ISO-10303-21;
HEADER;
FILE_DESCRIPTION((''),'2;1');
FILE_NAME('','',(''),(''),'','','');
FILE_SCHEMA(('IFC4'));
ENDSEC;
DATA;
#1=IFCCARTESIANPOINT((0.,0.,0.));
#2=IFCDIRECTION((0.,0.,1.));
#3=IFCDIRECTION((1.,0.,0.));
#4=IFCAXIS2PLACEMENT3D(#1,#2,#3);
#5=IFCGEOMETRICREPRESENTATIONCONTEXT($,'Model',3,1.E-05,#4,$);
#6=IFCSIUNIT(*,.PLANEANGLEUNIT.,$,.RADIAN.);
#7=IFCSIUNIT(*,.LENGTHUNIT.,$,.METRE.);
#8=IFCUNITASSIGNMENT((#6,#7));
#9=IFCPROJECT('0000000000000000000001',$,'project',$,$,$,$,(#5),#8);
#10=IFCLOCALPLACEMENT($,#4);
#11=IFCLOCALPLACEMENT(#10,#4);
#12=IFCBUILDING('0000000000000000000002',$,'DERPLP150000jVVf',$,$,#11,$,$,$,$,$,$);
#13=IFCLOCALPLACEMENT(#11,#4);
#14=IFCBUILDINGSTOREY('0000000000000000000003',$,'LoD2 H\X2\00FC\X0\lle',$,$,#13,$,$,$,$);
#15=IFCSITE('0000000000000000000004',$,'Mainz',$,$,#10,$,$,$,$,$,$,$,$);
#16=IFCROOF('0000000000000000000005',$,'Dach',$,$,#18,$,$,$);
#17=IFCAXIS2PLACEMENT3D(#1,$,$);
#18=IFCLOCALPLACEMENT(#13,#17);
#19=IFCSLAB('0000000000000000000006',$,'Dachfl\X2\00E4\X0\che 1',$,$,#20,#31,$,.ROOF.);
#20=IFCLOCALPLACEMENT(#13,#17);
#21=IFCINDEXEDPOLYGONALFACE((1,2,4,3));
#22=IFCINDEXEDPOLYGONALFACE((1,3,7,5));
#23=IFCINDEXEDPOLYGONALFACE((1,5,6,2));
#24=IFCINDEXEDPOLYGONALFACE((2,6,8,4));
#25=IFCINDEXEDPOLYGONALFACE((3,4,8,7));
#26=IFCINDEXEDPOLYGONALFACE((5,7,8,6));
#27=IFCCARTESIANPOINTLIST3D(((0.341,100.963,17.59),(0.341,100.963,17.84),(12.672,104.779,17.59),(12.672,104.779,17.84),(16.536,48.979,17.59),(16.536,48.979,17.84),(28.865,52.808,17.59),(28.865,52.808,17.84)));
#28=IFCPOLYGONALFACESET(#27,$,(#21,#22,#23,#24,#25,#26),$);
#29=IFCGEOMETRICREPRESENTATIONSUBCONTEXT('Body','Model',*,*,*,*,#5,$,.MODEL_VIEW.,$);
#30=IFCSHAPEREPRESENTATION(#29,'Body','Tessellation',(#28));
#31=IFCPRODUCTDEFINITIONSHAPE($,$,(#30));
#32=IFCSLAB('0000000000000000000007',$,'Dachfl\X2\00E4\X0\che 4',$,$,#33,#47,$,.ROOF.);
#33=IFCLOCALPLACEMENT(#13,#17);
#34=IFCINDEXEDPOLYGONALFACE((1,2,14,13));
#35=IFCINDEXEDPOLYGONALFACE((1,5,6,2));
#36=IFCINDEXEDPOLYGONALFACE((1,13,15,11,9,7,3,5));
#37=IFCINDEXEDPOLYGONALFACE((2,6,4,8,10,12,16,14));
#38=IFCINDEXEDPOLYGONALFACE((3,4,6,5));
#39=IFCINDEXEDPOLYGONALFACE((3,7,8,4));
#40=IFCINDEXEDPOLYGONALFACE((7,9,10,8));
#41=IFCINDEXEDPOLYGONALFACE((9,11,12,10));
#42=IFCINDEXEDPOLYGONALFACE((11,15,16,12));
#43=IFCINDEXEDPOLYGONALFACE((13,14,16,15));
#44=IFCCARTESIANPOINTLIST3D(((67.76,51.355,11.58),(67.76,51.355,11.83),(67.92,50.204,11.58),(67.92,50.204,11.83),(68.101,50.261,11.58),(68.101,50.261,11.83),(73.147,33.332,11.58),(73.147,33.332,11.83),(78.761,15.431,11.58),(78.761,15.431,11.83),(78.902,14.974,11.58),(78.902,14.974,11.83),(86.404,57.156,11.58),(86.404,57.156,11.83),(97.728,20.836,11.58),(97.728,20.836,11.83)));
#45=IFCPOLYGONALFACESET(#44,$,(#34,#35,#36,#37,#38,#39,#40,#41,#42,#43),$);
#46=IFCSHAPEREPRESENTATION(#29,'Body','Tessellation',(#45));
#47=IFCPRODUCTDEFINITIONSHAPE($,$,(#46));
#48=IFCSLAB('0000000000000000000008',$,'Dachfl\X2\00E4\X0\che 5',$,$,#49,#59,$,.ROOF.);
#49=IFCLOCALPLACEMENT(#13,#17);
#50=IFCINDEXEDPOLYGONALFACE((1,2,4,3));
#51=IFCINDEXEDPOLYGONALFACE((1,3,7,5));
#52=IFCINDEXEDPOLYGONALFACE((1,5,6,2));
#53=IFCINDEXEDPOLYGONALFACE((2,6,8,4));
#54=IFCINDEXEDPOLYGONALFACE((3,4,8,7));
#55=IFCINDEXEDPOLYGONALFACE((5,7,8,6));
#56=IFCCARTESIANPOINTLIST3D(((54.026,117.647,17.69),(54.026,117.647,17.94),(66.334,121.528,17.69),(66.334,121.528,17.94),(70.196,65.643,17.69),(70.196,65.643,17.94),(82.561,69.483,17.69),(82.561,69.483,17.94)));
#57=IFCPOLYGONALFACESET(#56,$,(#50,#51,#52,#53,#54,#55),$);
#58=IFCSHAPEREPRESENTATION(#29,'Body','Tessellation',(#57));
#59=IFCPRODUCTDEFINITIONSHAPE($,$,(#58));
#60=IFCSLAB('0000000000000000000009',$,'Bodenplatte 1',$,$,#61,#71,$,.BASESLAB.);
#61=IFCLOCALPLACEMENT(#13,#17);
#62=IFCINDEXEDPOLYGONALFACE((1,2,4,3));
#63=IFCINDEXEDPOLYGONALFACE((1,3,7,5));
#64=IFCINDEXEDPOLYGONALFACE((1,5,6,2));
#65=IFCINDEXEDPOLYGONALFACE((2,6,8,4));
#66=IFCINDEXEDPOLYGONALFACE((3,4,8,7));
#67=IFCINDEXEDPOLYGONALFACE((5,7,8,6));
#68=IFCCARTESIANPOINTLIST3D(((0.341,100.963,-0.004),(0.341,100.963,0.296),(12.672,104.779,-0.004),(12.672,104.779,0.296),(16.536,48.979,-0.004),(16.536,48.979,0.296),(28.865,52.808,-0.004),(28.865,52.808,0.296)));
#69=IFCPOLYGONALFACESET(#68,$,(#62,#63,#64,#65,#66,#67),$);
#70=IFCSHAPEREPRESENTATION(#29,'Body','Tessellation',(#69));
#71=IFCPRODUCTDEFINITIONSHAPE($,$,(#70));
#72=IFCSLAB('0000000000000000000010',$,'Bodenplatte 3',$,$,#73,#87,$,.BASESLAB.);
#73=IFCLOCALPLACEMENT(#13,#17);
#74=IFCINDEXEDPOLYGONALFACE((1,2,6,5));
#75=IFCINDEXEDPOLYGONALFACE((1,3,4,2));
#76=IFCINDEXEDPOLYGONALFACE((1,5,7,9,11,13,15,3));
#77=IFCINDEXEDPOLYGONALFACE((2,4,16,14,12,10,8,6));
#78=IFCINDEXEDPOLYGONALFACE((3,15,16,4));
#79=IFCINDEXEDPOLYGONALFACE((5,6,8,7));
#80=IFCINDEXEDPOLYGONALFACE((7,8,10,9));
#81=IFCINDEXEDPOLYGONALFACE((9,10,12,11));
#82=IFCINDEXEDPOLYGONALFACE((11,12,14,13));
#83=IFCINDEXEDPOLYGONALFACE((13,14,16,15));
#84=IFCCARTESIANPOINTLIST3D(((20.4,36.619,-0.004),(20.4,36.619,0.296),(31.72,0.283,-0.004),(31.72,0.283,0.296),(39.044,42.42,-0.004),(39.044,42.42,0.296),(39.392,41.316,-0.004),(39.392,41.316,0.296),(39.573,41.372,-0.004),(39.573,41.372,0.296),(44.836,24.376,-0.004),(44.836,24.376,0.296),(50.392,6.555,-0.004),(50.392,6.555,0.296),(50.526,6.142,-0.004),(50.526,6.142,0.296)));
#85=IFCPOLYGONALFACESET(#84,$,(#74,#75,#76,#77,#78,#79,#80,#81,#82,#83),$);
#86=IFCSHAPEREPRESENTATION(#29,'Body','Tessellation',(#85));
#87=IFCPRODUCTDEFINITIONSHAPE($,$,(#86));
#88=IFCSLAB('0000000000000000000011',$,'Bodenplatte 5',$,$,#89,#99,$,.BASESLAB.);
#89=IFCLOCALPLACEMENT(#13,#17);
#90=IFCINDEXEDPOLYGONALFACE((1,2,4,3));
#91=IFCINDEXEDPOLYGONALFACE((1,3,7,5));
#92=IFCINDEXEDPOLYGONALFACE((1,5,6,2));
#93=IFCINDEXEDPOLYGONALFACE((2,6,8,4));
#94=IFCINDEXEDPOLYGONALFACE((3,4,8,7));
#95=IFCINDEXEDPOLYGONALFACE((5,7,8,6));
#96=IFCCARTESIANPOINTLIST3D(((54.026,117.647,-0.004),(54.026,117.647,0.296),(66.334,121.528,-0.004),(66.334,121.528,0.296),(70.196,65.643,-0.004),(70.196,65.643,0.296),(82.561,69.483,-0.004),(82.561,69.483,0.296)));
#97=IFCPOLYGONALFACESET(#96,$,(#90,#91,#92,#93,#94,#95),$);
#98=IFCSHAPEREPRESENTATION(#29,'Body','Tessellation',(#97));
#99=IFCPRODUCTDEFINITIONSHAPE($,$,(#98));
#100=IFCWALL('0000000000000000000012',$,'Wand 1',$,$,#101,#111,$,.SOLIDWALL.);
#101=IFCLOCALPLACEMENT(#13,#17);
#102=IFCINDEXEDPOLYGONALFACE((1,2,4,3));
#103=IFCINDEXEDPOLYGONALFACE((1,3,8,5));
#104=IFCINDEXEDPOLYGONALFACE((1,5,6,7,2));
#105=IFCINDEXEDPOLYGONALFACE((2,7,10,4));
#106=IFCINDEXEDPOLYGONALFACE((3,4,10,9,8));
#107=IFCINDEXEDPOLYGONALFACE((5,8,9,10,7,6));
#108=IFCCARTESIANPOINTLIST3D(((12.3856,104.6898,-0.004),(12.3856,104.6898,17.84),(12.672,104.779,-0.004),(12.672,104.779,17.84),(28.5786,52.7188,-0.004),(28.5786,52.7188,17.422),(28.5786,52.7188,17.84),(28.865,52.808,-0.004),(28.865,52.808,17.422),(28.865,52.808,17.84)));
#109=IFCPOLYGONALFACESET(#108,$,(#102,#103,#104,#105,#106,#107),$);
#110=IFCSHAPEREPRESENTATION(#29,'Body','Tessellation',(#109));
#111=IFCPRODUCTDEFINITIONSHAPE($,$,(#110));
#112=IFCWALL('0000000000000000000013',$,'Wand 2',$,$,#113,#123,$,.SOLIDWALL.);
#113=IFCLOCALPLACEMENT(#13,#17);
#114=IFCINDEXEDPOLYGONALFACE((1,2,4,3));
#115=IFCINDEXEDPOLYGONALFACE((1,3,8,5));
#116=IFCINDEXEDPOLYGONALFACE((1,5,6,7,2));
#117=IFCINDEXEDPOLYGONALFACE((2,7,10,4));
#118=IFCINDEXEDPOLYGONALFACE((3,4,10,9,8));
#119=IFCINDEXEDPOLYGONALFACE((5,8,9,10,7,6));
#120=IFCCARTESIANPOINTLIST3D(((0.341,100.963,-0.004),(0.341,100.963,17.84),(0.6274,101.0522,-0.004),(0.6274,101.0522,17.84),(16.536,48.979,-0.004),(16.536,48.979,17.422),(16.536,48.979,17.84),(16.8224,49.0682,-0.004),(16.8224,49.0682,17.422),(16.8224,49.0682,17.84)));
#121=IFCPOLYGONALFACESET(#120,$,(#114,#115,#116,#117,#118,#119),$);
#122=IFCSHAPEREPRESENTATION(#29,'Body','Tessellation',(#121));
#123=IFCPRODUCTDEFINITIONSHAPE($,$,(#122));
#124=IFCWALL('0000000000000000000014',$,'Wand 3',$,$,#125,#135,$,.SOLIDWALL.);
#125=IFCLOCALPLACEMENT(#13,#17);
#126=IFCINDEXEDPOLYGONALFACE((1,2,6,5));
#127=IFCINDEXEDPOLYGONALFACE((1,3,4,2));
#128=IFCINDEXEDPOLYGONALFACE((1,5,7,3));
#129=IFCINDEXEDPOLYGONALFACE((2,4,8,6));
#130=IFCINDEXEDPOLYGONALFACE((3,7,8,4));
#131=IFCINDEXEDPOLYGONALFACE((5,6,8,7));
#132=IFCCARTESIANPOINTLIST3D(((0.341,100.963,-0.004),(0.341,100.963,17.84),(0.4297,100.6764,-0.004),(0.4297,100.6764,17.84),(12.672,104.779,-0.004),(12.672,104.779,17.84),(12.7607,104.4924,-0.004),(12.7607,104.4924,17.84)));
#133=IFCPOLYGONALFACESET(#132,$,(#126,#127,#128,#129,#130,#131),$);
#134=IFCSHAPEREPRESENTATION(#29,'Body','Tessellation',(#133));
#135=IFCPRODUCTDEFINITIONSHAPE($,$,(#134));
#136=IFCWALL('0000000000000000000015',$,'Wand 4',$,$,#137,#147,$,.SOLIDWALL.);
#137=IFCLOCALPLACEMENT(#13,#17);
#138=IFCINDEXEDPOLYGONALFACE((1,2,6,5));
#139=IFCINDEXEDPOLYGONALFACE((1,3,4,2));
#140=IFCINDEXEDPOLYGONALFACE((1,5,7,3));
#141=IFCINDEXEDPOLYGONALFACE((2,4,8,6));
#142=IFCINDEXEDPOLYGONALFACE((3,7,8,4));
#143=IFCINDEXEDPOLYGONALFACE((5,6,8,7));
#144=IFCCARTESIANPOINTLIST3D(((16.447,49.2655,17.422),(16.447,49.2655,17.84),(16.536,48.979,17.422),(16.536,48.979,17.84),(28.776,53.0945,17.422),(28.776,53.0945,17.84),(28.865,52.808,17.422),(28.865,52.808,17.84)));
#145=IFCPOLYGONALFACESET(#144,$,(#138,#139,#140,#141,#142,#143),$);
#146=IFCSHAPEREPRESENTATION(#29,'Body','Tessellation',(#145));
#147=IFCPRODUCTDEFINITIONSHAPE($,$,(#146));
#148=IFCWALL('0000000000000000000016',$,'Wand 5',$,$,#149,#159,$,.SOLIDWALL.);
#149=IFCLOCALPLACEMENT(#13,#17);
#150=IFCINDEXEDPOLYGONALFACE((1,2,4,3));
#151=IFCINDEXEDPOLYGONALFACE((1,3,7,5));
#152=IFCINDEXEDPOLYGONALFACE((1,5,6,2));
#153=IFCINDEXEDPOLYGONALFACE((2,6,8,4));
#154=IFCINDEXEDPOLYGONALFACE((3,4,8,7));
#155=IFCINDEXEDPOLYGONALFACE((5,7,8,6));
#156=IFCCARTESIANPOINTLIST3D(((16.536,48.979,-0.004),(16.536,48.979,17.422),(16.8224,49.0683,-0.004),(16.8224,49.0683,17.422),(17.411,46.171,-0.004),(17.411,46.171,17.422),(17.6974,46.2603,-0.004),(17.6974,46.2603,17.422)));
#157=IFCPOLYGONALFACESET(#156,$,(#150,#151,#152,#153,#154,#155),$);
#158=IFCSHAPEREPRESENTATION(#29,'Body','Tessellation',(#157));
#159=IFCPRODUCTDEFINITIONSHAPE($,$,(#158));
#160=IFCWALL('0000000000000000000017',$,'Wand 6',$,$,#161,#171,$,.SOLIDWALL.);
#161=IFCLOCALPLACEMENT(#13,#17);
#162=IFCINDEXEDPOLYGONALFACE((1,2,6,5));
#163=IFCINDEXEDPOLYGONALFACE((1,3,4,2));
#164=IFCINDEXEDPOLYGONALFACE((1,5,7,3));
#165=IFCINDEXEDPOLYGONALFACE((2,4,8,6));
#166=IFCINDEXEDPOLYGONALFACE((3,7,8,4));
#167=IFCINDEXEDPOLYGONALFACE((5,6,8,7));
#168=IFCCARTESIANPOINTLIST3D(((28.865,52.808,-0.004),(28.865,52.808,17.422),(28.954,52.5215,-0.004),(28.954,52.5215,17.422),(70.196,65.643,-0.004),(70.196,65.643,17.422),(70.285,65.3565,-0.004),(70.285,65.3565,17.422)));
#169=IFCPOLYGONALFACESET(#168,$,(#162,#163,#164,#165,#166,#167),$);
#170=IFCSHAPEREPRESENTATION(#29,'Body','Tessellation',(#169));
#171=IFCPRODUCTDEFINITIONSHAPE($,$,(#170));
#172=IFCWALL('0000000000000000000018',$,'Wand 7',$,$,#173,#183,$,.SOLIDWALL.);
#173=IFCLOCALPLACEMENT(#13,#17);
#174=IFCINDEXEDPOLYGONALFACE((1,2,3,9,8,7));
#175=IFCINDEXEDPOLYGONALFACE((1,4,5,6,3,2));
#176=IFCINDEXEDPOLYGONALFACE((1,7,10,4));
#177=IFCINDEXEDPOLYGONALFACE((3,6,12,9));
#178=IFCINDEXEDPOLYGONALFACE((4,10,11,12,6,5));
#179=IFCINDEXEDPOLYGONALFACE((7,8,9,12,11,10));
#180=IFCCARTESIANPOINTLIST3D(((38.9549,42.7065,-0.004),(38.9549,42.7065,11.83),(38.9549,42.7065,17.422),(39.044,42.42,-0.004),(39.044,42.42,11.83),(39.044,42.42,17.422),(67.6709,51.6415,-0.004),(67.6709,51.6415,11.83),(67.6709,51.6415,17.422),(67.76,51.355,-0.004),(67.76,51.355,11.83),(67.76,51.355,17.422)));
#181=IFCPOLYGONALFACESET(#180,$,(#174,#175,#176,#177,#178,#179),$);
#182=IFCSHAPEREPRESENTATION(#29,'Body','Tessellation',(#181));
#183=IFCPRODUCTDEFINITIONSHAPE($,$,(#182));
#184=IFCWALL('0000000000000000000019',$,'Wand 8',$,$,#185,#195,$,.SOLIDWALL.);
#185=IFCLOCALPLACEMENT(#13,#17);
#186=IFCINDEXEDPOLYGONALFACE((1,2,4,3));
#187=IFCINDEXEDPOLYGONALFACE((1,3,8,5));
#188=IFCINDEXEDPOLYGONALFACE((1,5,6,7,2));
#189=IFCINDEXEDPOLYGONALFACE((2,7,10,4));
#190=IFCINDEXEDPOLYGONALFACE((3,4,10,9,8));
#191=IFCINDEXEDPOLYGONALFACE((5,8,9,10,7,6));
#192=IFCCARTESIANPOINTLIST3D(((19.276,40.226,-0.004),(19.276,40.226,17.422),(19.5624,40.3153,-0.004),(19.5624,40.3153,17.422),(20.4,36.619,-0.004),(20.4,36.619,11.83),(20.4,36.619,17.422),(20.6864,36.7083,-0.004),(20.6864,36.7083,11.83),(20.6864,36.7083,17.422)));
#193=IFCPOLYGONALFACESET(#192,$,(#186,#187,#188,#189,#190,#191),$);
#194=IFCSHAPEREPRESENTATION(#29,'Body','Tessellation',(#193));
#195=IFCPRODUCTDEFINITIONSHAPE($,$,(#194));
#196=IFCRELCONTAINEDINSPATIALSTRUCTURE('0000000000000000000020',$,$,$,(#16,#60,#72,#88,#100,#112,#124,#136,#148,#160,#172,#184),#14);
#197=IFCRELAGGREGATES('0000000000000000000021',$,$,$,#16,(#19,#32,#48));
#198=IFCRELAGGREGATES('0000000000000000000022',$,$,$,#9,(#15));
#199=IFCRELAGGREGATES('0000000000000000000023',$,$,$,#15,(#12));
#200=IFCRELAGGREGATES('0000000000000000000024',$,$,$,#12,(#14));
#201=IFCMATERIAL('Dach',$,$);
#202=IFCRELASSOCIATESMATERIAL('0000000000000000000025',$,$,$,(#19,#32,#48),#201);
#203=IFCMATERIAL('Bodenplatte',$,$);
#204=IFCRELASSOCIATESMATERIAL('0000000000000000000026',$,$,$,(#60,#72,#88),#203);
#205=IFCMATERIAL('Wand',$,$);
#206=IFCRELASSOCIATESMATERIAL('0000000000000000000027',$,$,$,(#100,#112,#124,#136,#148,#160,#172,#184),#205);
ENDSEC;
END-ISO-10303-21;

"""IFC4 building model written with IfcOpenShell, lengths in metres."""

from ifc_helpers import new_model, si_unit, frame, origin_with_axes, place, context, subcontext, project, spatial, polyline, outline, extrude, material, element, aggregate, save


model = new_model("IFC4")

# Units and contexts
model_context = context("Model", 3, precision=1e-05, world=origin_with_axes())
body_context = subcontext(model_context, "Body", "Model", "MODEL_VIEW")
ifc_project = project(units=[si_unit("PLANEANGLEUNIT", "RADIAN"), si_unit("LENGTHUNIT", "METRE")], contexts=[model_context])

# Site, building, storey
site_placement = place(None, origin_with_axes())
site = spatial("IfcSite", under=ifc_project, at=site_placement, Name="Mainz")
building_placement = place(site_placement, origin_with_axes())
building = spatial("IfcBuilding", under=site, at=building_placement, Name="DERPLP150000jVVf")
storey_placement = place(building_placement, origin_with_axes())
storey = spatial("IfcBuildingStorey", under=building, at=storey_placement, Name="LoD2 Hülle")

# Roof, slabs
roof_placement = place(storey_placement, origin_with_axes())
roof = element("IfcRoof", 1, at=roof_placement, inside=storey, Name="Dach")
ifc_material_1 = material(Name="Dach")
slab_1_placement = place(roof_placement, origin_with_axes())
slab_1 = element("IfcSlab", 2, at=slab_1_placement, material=ifc_material_1, Name="Dachfläche 1", PredefinedType="ROOF", context=body_context, shape_type="SweptSolid", body=[
    extrude(outline(polyline([(0.0, 0.0), (54.4483, 0.0), (54.4597, 12.9099), (0.0244, 12.9079), (0.0, 0.0)])), frame((0.341, 100.963, 17.84), z_axis=(0.0, 0.0, 1.0), x_axis=(0.297438, -0.954741, 0.0)), (0.0, 0.0, -1.0), 0.25),
])
slab_2_placement = place(roof_placement, origin_with_axes())
slab_2 = element("IfcSlab", 3, at=slab_2_placement, material=ifc_material_1, Name="Dachfläche 4", PredefinedType="ROOF", context=body_context, shape_type="SweptSolid", body=[
    extrude(outline(polyline([(0.0, 0.0), (38.0444, 0.0), (38.0558, 19.5256), (36.9098, 19.5257), (36.9093, 19.7155), (19.2462, 19.7474), (0.4856, 19.7161), (0.0073, 19.7175), (0.0, 0.0)])), frame((97.728, 20.836, 11.83), z_axis=(0.0, 0.0, 1.0), x_axis=(-0.297652, 0.954674, 0.0)), (0.0, 0.0, -1.0), 0.25),
])
slab_3_placement = place(roof_placement, origin_with_axes())
slab_3 = element("IfcSlab", 4, at=slab_3_placement, material=ifc_material_1, Name="Dachfläche 5", PredefinedType="ROOF", context=body_context, shape_type="SweptSolid", body=[
    extrude(outline(polyline([(0.0, 0.0), (54.516, 0.0), (54.4745, 12.9053), (0.0146, 12.9475), (0.0, 0.0)])), frame((82.561, 69.483, 17.94), z_axis=(0.0, 0.0, 1.0), x_axis=(-0.297656, 0.954673, 0.0)), (0.0, 0.0, -1.0), 0.25),
])
aggregate(roof, [slab_1, slab_2, slab_3])

# Slabs
ifc_material_2 = material(Name="Bodenplatte")
slab_4_placement = place(storey_placement, origin_with_axes())
element("IfcSlab", 5, at=slab_4_placement, inside=storey, material=ifc_material_2, Name="Bodenplatte 1", PredefinedType="BASESLAB", context=body_context, shape_type="SweptSolid", body=[
    extrude(outline(polyline([(0.0, 0.0), (54.4353, 0.0), (54.4234, 12.9099), (-0.0249, 12.9079), (0.0, 0.0)])), frame((12.672, 104.779, -0.004), z_axis=(0.0, 0.0, -1.0), x_axis=(0.297473, -0.95473, 0.0)), (0.0, 0.0, -1.0), 0.3),
])
slab_5_placement = place(storey_placement, origin_with_axes())
element("IfcSlab", 6, at=slab_5_placement, inside=storey, material=ifc_material_2, Name="Bodenplatte 3", PredefinedType="BASESLAB", context=body_context, shape_type="SweptSolid", body=[
    extrude(outline(polyline([(0.0, 0.0), (38.0585, 0.0), (38.0515, 19.5256), (36.894, 19.5295), (36.8936, 19.719), (19.1014, 19.6885), (0.4344, 19.6925), (0.0002, 19.6976), (0.0, 0.0)])), frame((31.72, 0.283, -0.004), z_axis=(0.0, 0.0, -1.0), x_axis=(-0.297437, 0.954741, 0.0)), (0.0, 0.0, -1.0), 0.3),
])
slab_6_placement = place(storey_placement, origin_with_axes())
element("IfcSlab", 7, at=slab_6_placement, inside=storey, material=ifc_material_2, Name="Bodenplatte 5", PredefinedType="BASESLAB", context=body_context, shape_type="SweptSolid", body=[
    extrude(outline(polyline([(0.0, 0.0), (54.4599, 0.0), (54.5115, 12.9053), (-0.0045, 12.9475), (0.0, 0.0)])), frame((70.196, 65.643, -0.004), z_axis=(0.0, 0.0, -1.0), x_axis=(-0.296916, 0.954904, 0.0)), (0.0, 0.0, -1.0), 0.3),
])

# Walls
ifc_material_3 = material(Name="Wand")
wall_1_placement = place(storey_placement, origin_with_axes())
element("IfcWall", 8, at=wall_1_placement, inside=storey, material=ifc_material_3, Name="Wand 1", PredefinedType="SOLIDWALL", context=body_context, shape_type="SweptSolid", body=[
    extrude(outline(polyline([(0.0, 0.0), (54.4353, 0.0), (54.4353, 0.418), (54.4353, 17.844), (0.0, 17.844), (0.0, 0.0)])), frame((12.672, 104.779, 17.84), z_axis=(0.95473, 0.297473, 0.0), x_axis=(0.297473, -0.95473, 0.0)), (0.0, 0.0, -1.0), 0.3),
])
wall_2_placement = place(storey_placement, origin_with_axes())
element("IfcWall", 9, at=wall_2_placement, inside=storey, material=ifc_material_3, Name="Wand 2", PredefinedType="SOLIDWALL", context=body_context, shape_type="SweptSolid", body=[
    extrude(outline(polyline([(0.0, 0.0), (54.4483, 0.0), (54.4483, 17.844), (0.0, 17.844), (0.0, 0.418), (0.0, 0.0)])), frame((16.536, 48.979, 17.84), z_axis=(-0.954741, -0.297438, 0.0), x_axis=(-0.297438, 0.954741, 0.0)), (0.0, 0.0, -1.0), 0.3),
])
wall_3_placement = place(storey_placement, origin_with_axes())
element("IfcWall", 10, at=wall_3_placement, inside=storey, material=ifc_material_3, Name="Wand 3", PredefinedType="SOLIDWALL", context=body_context, shape_type="SweptSolid", body=[
    extrude(outline(polyline([(0.0, 0.0), (12.908, 0.0), (12.908, 17.844), (0.0, 17.844), (0.0, 0.0)])), frame((0.341, 100.963, 17.84), z_axis=(-0.295632, 0.955302, 0.0), x_axis=(0.955302, 0.295632, 0.0)), (0.0, 0.0, -1.0), 0.3),
])
wall_4_placement = place(storey_placement, origin_with_axes())
element("IfcWall", 11, at=wall_4_placement, inside=storey, material=ifc_material_3, Name="Wand 4", PredefinedType="SOLIDWALL", context=body_context, shape_type="SweptSolid", body=[
    extrude(outline(polyline([(0.0, 0.0), (12.9099, 0.0), (12.9099, 0.418), (0.0, 0.418), (0.0, 0.0)])), frame((16.536, 48.979, 17.422), z_axis=(0.296594, -0.955004, 0.0), x_axis=(0.955004, 0.296594, 0.0)), (0.0, 0.0, -1.0), 0.3),
])
wall_5_placement = place(storey_placement, origin_with_axes())
element("IfcWall", 12, at=wall_5_placement, inside=storey, material=ifc_material_3, Name="Wand 5", PredefinedType="SOLIDWALL", context=body_context, shape_type="SweptSolid", body=[
    extrude(outline(polyline([(0.0, 0.0), (2.9412, 0.0), (2.9412, 17.426), (0.0, 17.426), (0.0, 0.0)])), frame((17.411, 46.171, 17.422), z_axis=(-0.954722, -0.297501, 0.0), x_axis=(-0.297501, 0.954722, 0.0)), (0.0, 0.0, -1.0), 0.3),
])
wall_6_placement = place(storey_placement, origin_with_axes())
element("IfcWall", 13, at=wall_6_placement, inside=storey, material=ifc_material_3, Name="Wand 6", PredefinedType="SOLIDWALL", context=body_context, shape_type="SweptSolid", body=[
    extrude(outline(polyline([(0.0, 0.0), (43.278, 0.0), (43.278, 17.426), (0.0, 17.426), (0.0, 0.0)])), frame((28.865, 52.808, 17.422), z_axis=(-0.296571, 0.955011, 0.0), x_axis=(0.955011, 0.296571, 0.0)), (0.0, 0.0, -1.0), 0.3),
])
wall_7_placement = place(storey_placement, origin_with_axes())
element("IfcWall", 14, at=wall_7_placement, inside=storey, material=ifc_material_3, Name="Wand 7", PredefinedType="SOLIDWALL", context=body_context, shape_type="SweptSolid", body=[
    extrude(outline(polyline([(0.0, 0.0), (30.074, 0.0), (30.074, 5.592), (30.074, 17.426), (0.0, 17.426), (0.0, 5.592), (0.0, 0.0)])), frame((67.76, 51.355, 17.422), z_axis=(0.297101, -0.954846, 0.0), x_axis=(-0.954846, -0.297101, 0.0)), (0.0, 0.0, -1.0), 0.3),
])
wall_8_placement = place(storey_placement, origin_with_axes())
element("IfcWall", 15, at=wall_8_placement, inside=storey, material=ifc_material_3, Name="Wand 8", PredefinedType="SOLIDWALL", context=body_context, shape_type="SweptSolid", body=[
    extrude(outline(polyline([(0.0, 0.0), (3.7781, 0.0), (3.7781, 17.426), (0.0, 17.426), (0.0, 5.592), (0.0, 0.0)])), frame((20.4, 36.619, 17.422), z_axis=(-0.95472, -0.297506, 0.0), x_axis=(-0.297506, 0.95472, 0.0)), (0.0, 0.0, -1.0), 0.3),
])

save(model, "model.ifc")
